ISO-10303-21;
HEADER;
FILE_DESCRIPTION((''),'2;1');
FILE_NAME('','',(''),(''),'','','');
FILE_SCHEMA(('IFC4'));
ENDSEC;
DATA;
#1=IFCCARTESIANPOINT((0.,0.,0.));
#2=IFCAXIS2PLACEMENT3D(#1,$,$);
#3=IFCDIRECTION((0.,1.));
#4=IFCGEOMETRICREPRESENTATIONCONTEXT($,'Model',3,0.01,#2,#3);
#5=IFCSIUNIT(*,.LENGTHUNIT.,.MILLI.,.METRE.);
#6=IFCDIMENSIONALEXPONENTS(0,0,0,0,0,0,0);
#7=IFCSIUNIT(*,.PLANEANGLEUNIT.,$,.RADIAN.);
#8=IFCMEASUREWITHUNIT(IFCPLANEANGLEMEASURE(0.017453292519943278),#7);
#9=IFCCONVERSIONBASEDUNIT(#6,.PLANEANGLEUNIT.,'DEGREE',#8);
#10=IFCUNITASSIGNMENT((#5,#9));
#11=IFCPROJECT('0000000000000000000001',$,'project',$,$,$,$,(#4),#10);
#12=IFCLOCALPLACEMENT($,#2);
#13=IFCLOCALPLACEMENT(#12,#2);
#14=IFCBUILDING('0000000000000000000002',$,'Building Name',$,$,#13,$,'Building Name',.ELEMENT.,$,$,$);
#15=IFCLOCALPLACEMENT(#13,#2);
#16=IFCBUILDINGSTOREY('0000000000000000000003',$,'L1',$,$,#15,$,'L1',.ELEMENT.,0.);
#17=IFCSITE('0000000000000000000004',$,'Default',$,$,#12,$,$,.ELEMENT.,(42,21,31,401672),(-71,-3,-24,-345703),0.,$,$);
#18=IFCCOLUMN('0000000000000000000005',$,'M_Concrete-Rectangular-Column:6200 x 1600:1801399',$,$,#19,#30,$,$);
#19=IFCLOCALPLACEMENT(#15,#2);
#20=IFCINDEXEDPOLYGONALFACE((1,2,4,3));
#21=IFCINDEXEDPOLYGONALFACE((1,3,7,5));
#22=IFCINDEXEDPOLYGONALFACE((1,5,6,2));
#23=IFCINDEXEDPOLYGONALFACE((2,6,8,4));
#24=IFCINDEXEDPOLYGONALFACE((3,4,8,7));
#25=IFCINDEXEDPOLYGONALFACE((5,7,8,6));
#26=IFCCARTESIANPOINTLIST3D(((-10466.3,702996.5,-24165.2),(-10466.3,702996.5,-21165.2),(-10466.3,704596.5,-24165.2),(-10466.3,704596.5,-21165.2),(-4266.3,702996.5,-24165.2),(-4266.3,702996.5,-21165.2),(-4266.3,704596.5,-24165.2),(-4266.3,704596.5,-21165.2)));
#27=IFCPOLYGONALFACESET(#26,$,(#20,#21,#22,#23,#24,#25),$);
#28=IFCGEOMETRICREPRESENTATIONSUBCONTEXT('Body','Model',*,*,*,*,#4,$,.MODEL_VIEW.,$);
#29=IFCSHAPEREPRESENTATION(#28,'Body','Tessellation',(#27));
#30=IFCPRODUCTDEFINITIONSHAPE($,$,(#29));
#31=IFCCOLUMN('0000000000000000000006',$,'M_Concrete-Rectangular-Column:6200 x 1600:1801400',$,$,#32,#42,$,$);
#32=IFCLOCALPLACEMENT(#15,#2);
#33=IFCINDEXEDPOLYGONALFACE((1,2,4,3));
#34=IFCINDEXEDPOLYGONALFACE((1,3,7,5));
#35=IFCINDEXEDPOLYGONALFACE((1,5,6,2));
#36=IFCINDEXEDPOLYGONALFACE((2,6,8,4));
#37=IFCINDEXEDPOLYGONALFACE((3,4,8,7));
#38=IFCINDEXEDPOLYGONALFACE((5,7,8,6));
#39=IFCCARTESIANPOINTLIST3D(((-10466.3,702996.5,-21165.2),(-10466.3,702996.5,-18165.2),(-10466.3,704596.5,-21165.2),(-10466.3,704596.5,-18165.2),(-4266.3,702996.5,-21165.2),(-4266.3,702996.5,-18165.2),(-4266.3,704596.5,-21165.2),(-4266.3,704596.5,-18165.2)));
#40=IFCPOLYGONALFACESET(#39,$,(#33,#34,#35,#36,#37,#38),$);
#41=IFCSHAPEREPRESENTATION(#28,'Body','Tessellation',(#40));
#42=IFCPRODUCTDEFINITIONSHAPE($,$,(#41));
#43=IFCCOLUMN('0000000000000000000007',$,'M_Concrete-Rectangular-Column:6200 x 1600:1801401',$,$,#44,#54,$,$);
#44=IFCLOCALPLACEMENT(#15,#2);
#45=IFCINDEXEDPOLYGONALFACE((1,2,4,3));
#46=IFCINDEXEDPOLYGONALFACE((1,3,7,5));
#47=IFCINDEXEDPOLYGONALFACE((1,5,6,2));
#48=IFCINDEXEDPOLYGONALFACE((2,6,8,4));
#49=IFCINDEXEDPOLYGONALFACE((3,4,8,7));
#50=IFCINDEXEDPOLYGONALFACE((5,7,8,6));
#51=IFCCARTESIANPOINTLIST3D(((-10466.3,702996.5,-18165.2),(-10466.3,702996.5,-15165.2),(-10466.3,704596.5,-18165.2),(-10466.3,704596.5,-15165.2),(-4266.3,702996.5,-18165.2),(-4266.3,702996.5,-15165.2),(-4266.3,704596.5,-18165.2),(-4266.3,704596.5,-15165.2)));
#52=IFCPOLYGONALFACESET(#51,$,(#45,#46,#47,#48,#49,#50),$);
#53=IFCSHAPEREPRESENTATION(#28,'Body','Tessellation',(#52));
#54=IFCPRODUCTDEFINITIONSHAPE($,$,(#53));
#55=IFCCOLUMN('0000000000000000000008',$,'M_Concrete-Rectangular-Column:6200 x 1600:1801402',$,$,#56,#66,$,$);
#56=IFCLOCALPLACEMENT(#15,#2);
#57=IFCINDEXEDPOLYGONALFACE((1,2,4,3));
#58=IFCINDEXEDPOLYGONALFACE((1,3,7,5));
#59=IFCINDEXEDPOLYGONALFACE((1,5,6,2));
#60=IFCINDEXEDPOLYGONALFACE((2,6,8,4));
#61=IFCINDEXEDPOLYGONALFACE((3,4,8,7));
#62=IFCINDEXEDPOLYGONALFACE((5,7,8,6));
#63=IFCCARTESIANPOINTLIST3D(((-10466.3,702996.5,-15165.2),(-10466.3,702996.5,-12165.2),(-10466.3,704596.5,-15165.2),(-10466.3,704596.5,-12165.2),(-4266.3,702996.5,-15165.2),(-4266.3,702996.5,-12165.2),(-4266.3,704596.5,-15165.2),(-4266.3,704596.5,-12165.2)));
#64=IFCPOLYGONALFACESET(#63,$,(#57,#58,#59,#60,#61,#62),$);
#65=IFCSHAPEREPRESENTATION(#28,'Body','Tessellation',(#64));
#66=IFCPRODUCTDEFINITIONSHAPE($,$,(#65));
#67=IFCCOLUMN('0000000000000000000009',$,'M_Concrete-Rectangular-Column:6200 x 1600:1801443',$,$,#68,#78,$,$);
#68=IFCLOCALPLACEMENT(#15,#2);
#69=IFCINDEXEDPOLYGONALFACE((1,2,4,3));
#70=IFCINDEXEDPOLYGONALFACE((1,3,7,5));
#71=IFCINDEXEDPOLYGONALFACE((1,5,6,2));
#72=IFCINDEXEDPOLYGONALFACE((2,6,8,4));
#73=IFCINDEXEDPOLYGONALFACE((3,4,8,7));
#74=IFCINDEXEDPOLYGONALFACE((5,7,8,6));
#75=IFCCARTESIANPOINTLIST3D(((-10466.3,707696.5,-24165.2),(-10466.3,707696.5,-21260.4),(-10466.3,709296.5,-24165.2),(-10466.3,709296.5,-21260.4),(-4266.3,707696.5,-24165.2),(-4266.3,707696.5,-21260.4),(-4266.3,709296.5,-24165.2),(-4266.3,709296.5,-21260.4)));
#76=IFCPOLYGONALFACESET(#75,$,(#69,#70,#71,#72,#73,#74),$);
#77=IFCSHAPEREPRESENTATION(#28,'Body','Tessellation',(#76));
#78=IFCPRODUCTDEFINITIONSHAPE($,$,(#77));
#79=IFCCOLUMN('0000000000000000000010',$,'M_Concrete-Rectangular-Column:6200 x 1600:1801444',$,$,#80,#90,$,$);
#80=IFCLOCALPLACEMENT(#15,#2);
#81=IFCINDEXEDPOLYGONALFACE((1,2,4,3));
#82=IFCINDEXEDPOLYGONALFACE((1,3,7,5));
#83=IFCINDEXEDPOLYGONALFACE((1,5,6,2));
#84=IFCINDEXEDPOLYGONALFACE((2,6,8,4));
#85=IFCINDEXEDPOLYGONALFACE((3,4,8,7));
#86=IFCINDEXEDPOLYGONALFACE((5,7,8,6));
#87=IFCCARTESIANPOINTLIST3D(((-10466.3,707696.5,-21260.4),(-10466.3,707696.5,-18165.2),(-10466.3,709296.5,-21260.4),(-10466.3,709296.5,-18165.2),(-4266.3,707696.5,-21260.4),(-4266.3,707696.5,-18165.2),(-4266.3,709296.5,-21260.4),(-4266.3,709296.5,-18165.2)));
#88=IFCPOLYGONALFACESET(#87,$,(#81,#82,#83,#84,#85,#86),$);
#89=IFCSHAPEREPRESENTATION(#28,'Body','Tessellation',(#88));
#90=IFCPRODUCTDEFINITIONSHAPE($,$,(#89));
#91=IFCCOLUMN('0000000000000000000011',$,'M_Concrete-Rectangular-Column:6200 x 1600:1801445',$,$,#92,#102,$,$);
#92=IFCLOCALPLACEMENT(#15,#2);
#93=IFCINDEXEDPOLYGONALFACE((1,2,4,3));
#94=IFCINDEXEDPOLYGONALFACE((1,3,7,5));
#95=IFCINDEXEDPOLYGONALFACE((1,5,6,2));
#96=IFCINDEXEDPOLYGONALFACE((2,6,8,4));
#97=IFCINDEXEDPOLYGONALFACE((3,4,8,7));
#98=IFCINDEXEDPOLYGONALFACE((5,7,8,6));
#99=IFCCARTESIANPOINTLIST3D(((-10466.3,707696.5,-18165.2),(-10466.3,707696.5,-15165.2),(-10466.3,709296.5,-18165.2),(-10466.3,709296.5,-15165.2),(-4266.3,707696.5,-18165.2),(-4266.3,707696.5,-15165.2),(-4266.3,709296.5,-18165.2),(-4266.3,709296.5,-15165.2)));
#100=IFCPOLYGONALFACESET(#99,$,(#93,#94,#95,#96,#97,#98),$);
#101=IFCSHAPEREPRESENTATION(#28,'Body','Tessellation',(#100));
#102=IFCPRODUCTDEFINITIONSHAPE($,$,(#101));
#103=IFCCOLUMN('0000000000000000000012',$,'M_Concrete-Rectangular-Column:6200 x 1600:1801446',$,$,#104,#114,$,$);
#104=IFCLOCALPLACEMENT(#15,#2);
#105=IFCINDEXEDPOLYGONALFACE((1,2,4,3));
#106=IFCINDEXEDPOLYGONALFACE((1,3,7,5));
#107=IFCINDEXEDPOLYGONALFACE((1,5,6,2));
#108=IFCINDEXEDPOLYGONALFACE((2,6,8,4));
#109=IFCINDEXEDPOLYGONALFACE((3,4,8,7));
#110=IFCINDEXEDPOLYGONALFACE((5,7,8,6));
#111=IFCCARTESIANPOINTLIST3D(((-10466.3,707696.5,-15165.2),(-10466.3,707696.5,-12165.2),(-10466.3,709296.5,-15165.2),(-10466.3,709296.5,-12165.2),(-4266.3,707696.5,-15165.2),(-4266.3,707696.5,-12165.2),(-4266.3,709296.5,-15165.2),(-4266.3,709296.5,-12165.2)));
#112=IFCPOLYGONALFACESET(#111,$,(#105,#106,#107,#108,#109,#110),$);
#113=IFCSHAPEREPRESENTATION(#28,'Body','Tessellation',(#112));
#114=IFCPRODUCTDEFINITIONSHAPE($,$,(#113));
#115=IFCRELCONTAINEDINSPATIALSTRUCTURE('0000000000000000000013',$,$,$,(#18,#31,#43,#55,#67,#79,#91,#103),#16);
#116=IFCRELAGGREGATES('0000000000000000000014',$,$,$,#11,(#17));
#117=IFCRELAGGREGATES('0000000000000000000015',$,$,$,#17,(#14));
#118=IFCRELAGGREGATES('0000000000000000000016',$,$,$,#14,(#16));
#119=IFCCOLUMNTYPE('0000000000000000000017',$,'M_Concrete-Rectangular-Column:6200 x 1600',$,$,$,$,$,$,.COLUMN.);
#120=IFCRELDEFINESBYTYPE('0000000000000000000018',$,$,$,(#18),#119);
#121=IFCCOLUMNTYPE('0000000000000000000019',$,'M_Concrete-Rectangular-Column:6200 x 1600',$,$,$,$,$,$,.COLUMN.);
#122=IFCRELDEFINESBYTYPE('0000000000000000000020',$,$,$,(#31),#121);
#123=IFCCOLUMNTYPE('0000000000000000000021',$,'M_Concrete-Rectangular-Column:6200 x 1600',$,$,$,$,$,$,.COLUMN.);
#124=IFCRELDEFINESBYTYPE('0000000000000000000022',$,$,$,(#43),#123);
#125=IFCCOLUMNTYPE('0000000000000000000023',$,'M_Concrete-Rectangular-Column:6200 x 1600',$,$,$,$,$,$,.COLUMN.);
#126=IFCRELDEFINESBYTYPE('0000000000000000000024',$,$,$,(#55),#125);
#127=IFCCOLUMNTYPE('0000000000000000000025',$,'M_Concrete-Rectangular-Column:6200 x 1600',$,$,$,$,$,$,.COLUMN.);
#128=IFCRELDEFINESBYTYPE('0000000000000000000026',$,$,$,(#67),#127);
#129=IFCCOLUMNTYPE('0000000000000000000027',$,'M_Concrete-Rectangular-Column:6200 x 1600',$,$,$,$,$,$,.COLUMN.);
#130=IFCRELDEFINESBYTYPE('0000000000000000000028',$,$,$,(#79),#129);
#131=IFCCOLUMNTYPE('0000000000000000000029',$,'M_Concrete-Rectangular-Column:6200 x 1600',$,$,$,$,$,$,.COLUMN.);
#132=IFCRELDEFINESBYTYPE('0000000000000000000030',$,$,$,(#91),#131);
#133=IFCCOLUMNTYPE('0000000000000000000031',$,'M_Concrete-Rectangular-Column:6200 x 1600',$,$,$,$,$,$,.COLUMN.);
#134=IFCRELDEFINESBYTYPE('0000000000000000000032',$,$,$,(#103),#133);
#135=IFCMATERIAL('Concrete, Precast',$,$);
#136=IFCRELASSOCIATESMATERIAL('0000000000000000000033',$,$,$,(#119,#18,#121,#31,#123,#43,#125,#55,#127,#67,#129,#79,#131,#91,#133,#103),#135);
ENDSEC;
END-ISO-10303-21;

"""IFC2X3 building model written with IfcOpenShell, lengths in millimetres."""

from ifc_helpers import new_model, entity, si_unit, converted_unit, direction, frame, frame_2d, origin, place, context, subcontext, project, spatial, rectangle, extrude, source, transform, mapped, material, type_object, type_shapes, element, save


model = new_model("IFC2X3")

# Units and contexts
model_context = context("Model", 3, precision=0.01, world=origin(), true_north=direction((0.0, 1.0)))
body_context = subcontext(model_context, "Body", "Model", "MODEL_VIEW")
ifc_project = project(units=[si_unit("LENGTHUNIT", "METRE", prefix="MILLI"), converted_unit("PLANEANGLEUNIT", "DEGREE", entity("IfcPlaneAngleMeasure", 0.017453292519943278), si_unit("PLANEANGLEUNIT", "RADIAN"), dimensions=[0, 0, 0, 0, 0, 0, 0])], contexts=[model_context])

# Site, building, storey
site_placement = place(None, origin())
site = spatial("IfcSite", under=ifc_project, at=site_placement, Name="Default", CompositionType="ELEMENT", RefLatitude=(42, 21, 31, 401672), RefLongitude=(-71, -3, -24, -345703), RefElevation=0.0)
building_placement = place(site_placement, origin())
building = spatial("IfcBuilding", under=site, at=building_placement, Name="Building Name", LongName="Building Name", CompositionType="ELEMENT")
storey_placement = place(building_placement, origin())
storey = spatial("IfcBuildingStorey", under=building, at=storey_placement, Name="L1", LongName="L1", CompositionType="ELEMENT", Elevation=0.0)

# Columns
ifc_material_1 = material(Name="Concrete, Precast")
column_type_1 = type_object("IfcColumnType", Name="M_Concrete-Rectangular-Column:6200 x 1600", PredefinedType="COLUMN", material=ifc_material_1)
shared_shape_1 = source(origin(), body_context, "Body", "SweptSolid", [
    extrude(rectangle(XDim=1600.0, YDim=6200.0, at=frame_2d((0.0, 0.0), x_axis=(1.0, 0.0))), frame((-7366.3, 703796.5, -24165.2), z_axis=(0.0, 0.0, 1.0), x_axis=(0.0, -1.0, 0.0)), (0.0, 0.0, 1.0), 3000.0),
])
type_shapes(column_type_1, [shared_shape_1])
column_1_placement = place(storey_placement, origin())
element("IfcColumn", 1, at=column_1_placement, inside=storey, type_object=column_type_1, material=ifc_material_1, Name="M_Concrete-Rectangular-Column:6200 x 1600:1801399", context=body_context, shape_type="MappedRepresentation", body=[
    mapped(shared_shape_1, transform((0.0, 0.0, 0.0), scale=1.0)),
])
column_type_2 = type_object("IfcColumnType", Name="M_Concrete-Rectangular-Column:6200 x 1600", PredefinedType="COLUMN", material=ifc_material_1)
shared_shape_2 = source(origin(), body_context, "Body", "SweptSolid", [
    extrude(rectangle(XDim=1600.0, YDim=6200.0, at=frame_2d((0.0, 0.0), x_axis=(1.0, 0.0))), frame((-7366.3, 703796.5, -21165.2), z_axis=(0.0, 0.0, 1.0), x_axis=(0.0, -1.0, 0.0)), (0.0, 0.0, 1.0), 3000.0),
])
type_shapes(column_type_2, [shared_shape_2])
column_2_placement = place(storey_placement, origin())
element("IfcColumn", 2, at=column_2_placement, inside=storey, type_object=column_type_2, material=ifc_material_1, Name="M_Concrete-Rectangular-Column:6200 x 1600:1801400", context=body_context, shape_type="MappedRepresentation", body=[
    mapped(shared_shape_2, transform((0.0, 0.0, 0.0), scale=1.0)),
])
column_type_3 = type_object("IfcColumnType", Name="M_Concrete-Rectangular-Column:6200 x 1600", PredefinedType="COLUMN", material=ifc_material_1)
shared_shape_3 = source(origin(), body_context, "Body", "SweptSolid", [
    extrude(rectangle(XDim=1600.0, YDim=6200.0, at=frame_2d((0.0, 0.0), x_axis=(1.0, 0.0))), frame((-7366.3, 703796.5, -18165.2), z_axis=(0.0, 0.0, 1.0), x_axis=(0.0, -1.0, 0.0)), (0.0, 0.0, 1.0), 3000.0),
])
type_shapes(column_type_3, [shared_shape_3])
column_3_placement = place(storey_placement, origin())
element("IfcColumn", 3, at=column_3_placement, inside=storey, type_object=column_type_3, material=ifc_material_1, Name="M_Concrete-Rectangular-Column:6200 x 1600:1801401", context=body_context, shape_type="MappedRepresentation", body=[
    mapped(shared_shape_3, transform((0.0, 0.0, 0.0), scale=1.0)),
])
column_type_4 = type_object("IfcColumnType", Name="M_Concrete-Rectangular-Column:6200 x 1600", PredefinedType="COLUMN", material=ifc_material_1)
shared_shape_4 = source(origin(), body_context, "Body", "SweptSolid", [
    extrude(rectangle(XDim=1600.0, YDim=6200.0, at=frame_2d((0.0, 0.0), x_axis=(1.0, 0.0))), frame((-7366.3, 703796.5, -15165.2), z_axis=(0.0, 0.0, 1.0), x_axis=(0.0, -1.0, 0.0)), (0.0, 0.0, 1.0), 3000.0),
])
type_shapes(column_type_4, [shared_shape_4])
column_4_placement = place(storey_placement, origin())
element("IfcColumn", 4, at=column_4_placement, inside=storey, type_object=column_type_4, material=ifc_material_1, Name="M_Concrete-Rectangular-Column:6200 x 1600:1801402", context=body_context, shape_type="MappedRepresentation", body=[
    mapped(shared_shape_4, transform((0.0, 0.0, 0.0), scale=1.0)),
])
column_type_5 = type_object("IfcColumnType", Name="M_Concrete-Rectangular-Column:6200 x 1600", PredefinedType="COLUMN", material=ifc_material_1)
shared_shape_5 = source(origin(), body_context, "Body", "SweptSolid", [
    extrude(rectangle(XDim=1600.0, YDim=6200.0, at=frame_2d((0.0, 0.0), x_axis=(1.0, 0.0))), frame((-7366.3, 708496.5, -24165.2), z_axis=(0.0, 0.0, 1.0), x_axis=(0.0, -1.0, 0.0)), (0.0, 0.0, 1.0), 2904.8),
])
type_shapes(column_type_5, [shared_shape_5])
column_5_placement = place(storey_placement, origin())
element("IfcColumn", 5, at=column_5_placement, inside=storey, type_object=column_type_5, material=ifc_material_1, Name="M_Concrete-Rectangular-Column:6200 x 1600:1801443", context=body_context, shape_type="MappedRepresentation", body=[
    mapped(shared_shape_5, transform((0.0, 0.0, 0.0), scale=1.0)),
])
column_type_6 = type_object("IfcColumnType", Name="M_Concrete-Rectangular-Column:6200 x 1600", PredefinedType="COLUMN", material=ifc_material_1)
shared_shape_6 = source(origin(), body_context, "Body", "SweptSolid", [
    extrude(rectangle(XDim=1600.0, YDim=6200.0, at=frame_2d((0.0, 0.0), x_axis=(1.0, 0.0))), frame((-7366.3, 708496.5, -21260.4), z_axis=(0.0, 0.0, 1.0), x_axis=(0.0, -1.0, 0.0)), (0.0, 0.0, 1.0), 3095.2),
])
type_shapes(column_type_6, [shared_shape_6])
column_6_placement = place(storey_placement, origin())
element("IfcColumn", 6, at=column_6_placement, inside=storey, type_object=column_type_6, material=ifc_material_1, Name="M_Concrete-Rectangular-Column:6200 x 1600:1801444", context=body_context, shape_type="MappedRepresentation", body=[
    mapped(shared_shape_6, transform((0.0, 0.0, 0.0), scale=1.0)),
])
column_type_7 = type_object("IfcColumnType", Name="M_Concrete-Rectangular-Column:6200 x 1600", PredefinedType="COLUMN", material=ifc_material_1)
shared_shape_7 = source(origin(), body_context, "Body", "SweptSolid", [
    extrude(rectangle(XDim=1600.0, YDim=6200.0, at=frame_2d((0.0, 0.0), x_axis=(1.0, 0.0))), frame((-7366.3, 708496.5, -18165.2), z_axis=(0.0, 0.0, 1.0), x_axis=(0.0, -1.0, 0.0)), (0.0, 0.0, 1.0), 3000.0),
])
type_shapes(column_type_7, [shared_shape_7])
column_7_placement = place(storey_placement, origin())
element("IfcColumn", 7, at=column_7_placement, inside=storey, type_object=column_type_7, material=ifc_material_1, Name="M_Concrete-Rectangular-Column:6200 x 1600:1801445", context=body_context, shape_type="MappedRepresentation", body=[
    mapped(shared_shape_7, transform((0.0, 0.0, 0.0), scale=1.0)),
])
column_type_8 = type_object("IfcColumnType", Name="M_Concrete-Rectangular-Column:6200 x 1600", PredefinedType="COLUMN", material=ifc_material_1)
shared_shape_8 = source(origin(), body_context, "Body", "SweptSolid", [
    extrude(rectangle(XDim=1600.0, YDim=6200.0, at=frame_2d((0.0, 0.0), x_axis=(1.0, 0.0))), frame((-7366.3, 708496.5, -15165.2), z_axis=(0.0, 0.0, 1.0), x_axis=(0.0, -1.0, 0.0)), (0.0, 0.0, 1.0), 3000.0),
])
type_shapes(column_type_8, [shared_shape_8])
column_8_placement = place(storey_placement, origin())
element("IfcColumn", 8, at=column_8_placement, inside=storey, type_object=column_type_8, material=ifc_material_1, Name="M_Concrete-Rectangular-Column:6200 x 1600:1801446", context=body_context, shape_type="MappedRepresentation", body=[
    mapped(shared_shape_8, transform((0.0, 0.0, 0.0), scale=1.0)),
])

save(model, "model.ifc")
